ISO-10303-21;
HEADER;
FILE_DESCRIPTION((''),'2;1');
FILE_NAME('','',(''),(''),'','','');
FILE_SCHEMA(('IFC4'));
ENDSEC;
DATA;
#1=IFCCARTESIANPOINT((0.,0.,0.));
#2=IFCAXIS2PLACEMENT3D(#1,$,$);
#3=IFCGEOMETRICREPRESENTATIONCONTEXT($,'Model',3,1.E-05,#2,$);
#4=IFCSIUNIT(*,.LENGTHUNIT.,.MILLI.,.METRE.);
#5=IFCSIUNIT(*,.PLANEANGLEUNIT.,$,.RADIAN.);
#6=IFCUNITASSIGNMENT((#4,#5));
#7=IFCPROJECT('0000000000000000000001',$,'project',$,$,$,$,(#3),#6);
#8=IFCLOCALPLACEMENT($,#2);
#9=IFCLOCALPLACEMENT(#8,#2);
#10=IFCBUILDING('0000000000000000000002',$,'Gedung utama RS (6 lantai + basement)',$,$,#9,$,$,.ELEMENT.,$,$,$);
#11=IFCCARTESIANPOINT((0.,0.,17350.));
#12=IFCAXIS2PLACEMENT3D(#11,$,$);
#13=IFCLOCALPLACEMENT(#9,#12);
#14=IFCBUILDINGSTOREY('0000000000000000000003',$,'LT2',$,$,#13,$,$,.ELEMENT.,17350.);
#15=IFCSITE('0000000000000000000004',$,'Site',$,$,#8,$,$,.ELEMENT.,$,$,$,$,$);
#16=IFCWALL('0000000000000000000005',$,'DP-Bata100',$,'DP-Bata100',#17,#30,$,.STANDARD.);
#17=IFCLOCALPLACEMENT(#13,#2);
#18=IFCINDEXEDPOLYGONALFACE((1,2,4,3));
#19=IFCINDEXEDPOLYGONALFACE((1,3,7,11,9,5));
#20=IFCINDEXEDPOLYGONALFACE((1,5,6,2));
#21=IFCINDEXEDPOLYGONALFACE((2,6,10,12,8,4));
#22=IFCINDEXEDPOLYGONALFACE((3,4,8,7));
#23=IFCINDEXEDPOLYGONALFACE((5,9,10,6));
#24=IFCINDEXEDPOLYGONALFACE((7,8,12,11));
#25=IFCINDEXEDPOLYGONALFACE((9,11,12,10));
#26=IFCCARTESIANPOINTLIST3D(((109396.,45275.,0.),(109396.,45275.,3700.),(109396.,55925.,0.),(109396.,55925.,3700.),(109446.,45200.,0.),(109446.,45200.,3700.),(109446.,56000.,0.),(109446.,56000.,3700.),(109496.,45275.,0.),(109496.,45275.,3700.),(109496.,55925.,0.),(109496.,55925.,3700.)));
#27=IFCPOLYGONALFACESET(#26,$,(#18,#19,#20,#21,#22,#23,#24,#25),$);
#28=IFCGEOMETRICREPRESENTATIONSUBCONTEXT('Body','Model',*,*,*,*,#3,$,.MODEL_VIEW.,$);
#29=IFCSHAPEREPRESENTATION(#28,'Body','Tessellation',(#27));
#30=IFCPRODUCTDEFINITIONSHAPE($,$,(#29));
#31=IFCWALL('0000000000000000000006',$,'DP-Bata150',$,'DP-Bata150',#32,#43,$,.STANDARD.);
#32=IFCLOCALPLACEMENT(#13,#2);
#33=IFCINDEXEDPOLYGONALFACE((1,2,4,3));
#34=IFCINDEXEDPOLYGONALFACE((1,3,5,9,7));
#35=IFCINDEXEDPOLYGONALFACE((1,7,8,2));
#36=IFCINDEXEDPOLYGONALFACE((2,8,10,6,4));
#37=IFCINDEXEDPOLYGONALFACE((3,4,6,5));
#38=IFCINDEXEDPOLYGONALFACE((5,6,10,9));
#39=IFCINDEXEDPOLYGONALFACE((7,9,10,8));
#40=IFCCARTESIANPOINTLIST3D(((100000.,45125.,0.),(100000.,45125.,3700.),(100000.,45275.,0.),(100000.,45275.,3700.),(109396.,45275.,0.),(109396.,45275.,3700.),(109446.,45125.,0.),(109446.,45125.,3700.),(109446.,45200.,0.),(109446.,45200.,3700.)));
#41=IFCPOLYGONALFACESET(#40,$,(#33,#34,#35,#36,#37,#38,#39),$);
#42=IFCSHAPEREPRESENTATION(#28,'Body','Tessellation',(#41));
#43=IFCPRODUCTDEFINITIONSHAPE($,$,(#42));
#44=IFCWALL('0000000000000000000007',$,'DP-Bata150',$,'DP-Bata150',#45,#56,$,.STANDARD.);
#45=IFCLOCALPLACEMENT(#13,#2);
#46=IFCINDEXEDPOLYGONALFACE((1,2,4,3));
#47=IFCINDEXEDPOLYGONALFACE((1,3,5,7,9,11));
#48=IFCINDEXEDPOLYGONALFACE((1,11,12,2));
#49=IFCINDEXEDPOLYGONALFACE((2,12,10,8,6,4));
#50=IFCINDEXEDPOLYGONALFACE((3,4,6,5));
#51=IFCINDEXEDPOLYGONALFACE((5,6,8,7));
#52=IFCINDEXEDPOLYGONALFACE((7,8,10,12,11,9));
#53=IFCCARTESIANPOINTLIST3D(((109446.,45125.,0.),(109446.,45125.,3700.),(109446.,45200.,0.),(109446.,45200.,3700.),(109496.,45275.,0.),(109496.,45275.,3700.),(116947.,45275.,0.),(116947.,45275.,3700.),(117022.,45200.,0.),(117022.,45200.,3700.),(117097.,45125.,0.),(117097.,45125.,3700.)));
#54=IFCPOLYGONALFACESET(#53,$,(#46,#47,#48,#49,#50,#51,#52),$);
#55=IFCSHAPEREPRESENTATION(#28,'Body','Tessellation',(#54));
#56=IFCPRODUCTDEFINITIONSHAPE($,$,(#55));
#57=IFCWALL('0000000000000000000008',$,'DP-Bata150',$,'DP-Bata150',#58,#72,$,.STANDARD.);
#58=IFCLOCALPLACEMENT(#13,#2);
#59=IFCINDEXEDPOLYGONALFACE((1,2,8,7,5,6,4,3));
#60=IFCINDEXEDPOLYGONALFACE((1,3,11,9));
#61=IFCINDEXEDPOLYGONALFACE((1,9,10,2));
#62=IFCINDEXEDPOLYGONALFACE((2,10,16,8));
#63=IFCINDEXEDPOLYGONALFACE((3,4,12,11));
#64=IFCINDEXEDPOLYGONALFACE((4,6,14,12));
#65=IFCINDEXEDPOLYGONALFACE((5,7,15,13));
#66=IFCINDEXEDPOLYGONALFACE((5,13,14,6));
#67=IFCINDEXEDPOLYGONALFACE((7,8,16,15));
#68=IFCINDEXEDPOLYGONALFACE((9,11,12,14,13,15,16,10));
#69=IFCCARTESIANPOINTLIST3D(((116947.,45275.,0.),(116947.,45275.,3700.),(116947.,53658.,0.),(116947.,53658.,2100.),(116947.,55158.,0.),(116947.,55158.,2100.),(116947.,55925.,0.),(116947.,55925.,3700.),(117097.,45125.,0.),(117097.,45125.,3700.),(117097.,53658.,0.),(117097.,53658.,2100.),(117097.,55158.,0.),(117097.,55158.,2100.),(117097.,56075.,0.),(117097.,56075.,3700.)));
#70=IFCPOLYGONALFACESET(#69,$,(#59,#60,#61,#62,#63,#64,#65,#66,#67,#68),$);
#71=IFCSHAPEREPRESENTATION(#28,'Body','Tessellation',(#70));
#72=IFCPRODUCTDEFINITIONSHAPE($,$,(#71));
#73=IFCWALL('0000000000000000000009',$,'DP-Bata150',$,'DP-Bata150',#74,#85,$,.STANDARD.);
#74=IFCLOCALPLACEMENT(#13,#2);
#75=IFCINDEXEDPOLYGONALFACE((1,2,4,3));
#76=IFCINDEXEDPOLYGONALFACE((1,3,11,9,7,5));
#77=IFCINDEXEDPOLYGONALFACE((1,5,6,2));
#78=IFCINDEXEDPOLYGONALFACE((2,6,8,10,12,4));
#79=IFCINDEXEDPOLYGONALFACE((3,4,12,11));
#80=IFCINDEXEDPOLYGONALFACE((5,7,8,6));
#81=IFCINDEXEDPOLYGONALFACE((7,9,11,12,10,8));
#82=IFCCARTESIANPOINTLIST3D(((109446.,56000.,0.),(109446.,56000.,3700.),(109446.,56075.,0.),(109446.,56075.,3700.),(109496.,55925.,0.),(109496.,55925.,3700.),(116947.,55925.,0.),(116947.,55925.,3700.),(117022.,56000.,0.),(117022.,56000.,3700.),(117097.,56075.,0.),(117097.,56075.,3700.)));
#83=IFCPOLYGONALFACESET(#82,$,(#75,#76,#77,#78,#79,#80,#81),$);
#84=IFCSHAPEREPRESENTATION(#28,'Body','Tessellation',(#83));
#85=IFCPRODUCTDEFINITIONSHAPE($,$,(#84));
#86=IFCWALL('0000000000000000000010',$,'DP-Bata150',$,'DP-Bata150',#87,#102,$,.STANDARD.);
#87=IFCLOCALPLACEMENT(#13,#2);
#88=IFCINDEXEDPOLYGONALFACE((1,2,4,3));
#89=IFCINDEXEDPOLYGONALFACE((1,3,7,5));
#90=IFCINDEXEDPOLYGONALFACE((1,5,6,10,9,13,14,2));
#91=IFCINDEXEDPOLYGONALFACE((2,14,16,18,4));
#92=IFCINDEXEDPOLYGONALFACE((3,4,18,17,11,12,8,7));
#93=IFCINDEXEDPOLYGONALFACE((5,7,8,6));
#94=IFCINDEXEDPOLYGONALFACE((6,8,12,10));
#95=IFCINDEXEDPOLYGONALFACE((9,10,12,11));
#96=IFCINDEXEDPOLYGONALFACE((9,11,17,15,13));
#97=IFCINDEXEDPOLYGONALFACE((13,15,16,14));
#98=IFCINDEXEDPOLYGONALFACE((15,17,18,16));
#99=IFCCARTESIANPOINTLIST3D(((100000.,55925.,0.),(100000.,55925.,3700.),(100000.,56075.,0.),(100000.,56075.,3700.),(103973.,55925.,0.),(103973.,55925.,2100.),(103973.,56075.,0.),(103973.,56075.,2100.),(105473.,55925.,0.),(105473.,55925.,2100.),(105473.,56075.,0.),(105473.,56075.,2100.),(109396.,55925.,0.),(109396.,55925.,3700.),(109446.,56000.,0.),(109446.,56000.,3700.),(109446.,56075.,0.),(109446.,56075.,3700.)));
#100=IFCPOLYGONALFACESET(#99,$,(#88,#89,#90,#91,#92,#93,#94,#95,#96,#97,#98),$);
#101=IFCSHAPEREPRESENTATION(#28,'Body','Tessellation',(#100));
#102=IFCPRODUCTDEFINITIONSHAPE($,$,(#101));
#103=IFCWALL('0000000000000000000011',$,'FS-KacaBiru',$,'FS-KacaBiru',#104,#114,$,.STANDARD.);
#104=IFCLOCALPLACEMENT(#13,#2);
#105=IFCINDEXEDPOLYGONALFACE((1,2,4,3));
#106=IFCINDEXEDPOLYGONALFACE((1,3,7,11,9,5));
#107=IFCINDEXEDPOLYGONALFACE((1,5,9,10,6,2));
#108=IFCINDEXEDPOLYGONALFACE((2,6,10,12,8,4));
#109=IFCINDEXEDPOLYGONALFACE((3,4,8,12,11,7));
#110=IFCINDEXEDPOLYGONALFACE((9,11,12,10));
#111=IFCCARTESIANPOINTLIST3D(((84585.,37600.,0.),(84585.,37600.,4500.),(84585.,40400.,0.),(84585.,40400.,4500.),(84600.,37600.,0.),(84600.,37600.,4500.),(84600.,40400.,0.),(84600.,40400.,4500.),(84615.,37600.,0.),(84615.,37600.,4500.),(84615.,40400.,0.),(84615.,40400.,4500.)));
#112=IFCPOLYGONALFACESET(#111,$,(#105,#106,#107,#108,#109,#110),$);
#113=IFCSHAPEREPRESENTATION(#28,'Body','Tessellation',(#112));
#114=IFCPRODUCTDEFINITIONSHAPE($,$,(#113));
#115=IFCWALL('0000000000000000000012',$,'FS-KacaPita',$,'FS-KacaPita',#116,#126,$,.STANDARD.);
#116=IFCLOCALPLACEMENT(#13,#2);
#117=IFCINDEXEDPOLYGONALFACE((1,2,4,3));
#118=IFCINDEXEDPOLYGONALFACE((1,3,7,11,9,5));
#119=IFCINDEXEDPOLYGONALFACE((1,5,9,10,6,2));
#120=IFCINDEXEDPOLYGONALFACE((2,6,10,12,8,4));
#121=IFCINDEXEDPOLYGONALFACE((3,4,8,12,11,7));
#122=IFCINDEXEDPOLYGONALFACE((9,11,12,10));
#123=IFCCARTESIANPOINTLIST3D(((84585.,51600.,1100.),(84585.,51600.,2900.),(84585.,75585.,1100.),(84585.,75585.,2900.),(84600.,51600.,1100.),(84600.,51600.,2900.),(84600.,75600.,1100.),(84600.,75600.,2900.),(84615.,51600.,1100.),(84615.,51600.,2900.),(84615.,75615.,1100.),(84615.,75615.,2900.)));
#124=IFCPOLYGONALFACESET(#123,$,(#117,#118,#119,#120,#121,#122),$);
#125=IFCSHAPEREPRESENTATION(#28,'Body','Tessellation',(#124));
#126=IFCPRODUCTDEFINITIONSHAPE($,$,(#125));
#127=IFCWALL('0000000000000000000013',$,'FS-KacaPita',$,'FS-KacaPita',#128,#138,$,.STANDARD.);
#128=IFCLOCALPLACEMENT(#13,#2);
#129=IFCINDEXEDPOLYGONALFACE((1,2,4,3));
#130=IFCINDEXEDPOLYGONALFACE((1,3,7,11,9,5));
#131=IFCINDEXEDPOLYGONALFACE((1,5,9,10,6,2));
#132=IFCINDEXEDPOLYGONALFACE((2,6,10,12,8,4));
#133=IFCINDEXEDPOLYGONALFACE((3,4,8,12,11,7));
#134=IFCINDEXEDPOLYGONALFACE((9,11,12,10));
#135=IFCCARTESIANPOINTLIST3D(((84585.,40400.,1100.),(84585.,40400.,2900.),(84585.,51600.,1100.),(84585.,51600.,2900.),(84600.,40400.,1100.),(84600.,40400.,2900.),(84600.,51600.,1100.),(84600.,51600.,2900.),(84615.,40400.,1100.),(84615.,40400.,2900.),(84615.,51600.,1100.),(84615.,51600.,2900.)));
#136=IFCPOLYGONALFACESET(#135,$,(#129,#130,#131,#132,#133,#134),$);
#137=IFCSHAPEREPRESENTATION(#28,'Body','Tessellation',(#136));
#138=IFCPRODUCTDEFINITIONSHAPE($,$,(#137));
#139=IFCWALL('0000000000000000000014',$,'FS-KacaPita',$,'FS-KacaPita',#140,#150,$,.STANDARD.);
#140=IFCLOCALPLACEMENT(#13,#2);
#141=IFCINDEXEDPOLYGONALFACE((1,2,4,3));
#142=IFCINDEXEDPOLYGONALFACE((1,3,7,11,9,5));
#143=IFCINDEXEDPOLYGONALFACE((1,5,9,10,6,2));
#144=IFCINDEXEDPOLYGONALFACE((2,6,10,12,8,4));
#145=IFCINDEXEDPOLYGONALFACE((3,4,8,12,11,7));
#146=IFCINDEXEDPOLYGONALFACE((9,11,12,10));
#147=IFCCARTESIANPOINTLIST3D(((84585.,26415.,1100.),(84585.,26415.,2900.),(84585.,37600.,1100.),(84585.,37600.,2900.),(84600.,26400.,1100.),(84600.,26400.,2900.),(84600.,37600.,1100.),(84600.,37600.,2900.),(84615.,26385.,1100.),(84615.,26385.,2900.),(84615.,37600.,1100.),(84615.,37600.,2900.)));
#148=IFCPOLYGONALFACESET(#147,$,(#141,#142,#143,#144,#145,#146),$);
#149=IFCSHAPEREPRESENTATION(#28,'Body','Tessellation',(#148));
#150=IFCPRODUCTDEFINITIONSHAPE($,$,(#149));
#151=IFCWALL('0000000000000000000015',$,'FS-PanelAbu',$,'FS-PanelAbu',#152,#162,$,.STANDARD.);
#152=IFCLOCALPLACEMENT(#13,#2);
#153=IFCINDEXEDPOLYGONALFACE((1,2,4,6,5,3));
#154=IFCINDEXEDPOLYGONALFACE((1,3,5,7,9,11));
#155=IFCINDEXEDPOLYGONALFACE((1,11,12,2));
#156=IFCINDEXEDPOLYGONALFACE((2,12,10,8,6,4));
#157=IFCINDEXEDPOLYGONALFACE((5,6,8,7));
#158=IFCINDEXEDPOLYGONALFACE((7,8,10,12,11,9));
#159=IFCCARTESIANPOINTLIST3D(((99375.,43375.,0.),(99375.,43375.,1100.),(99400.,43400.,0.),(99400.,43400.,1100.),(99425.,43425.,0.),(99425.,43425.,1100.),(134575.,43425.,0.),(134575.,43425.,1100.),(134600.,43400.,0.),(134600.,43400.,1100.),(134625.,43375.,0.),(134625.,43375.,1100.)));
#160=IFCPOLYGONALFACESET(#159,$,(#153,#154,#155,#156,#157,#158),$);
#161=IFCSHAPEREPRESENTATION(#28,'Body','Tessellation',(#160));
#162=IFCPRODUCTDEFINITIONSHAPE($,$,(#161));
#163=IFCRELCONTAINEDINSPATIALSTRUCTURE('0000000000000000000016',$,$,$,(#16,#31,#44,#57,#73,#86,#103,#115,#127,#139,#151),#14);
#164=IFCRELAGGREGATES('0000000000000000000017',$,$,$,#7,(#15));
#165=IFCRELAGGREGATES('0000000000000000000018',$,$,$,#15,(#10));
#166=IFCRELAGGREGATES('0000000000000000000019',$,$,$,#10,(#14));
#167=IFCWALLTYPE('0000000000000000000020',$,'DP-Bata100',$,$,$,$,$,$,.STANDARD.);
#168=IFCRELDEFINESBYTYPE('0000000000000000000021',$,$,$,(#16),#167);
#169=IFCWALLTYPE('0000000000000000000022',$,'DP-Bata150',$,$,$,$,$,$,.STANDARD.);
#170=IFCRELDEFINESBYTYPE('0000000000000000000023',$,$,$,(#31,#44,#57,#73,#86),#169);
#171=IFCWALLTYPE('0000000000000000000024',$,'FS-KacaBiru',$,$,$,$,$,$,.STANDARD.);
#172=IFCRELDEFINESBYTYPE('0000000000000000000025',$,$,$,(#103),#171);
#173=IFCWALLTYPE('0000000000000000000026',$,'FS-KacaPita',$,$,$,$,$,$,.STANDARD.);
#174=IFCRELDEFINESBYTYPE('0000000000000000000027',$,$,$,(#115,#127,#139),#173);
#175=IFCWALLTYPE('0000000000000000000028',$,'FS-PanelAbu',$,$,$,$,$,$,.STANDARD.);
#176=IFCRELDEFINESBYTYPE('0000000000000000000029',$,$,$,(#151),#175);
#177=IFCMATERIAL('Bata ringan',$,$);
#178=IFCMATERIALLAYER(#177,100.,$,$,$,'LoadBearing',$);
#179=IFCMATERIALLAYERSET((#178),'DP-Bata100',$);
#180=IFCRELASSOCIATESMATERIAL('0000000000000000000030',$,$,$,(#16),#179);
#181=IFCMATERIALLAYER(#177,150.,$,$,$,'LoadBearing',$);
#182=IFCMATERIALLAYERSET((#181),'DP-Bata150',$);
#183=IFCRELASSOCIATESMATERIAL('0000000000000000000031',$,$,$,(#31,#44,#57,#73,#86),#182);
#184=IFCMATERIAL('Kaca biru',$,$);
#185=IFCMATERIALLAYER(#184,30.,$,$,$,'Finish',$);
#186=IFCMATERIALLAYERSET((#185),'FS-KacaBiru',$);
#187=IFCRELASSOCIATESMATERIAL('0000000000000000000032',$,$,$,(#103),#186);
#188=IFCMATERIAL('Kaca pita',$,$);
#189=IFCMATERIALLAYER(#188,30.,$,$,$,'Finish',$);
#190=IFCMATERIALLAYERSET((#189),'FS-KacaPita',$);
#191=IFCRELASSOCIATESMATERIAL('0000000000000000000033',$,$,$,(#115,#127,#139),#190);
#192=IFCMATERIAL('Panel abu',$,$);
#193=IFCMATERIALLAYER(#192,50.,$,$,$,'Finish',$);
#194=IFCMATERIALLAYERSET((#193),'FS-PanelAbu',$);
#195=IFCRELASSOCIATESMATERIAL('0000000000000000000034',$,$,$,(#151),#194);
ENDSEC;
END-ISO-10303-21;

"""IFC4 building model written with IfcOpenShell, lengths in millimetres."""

from ifc_helpers import new_model, si_unit, frame, frame_2d, origin, place, context, subcontext, project, spatial, polyline, rectangle, outline, extrude, material, layer, layer_set, layer_usage, type_object, element, save


model = new_model("IFC4")

# Units and contexts
model_context = context("Model", 3, precision=1e-05, world=origin())
body_context = subcontext(model_context, "Body", "Model", "MODEL_VIEW")
ifc_project = project(units=[si_unit("LENGTHUNIT", "METRE", prefix="MILLI"), si_unit("PLANEANGLEUNIT", "RADIAN")], contexts=[model_context])

# Site, building, storey
site_placement = place(None, origin())
site = spatial("IfcSite", under=ifc_project, at=site_placement, Name="Site", CompositionType="ELEMENT")
building_placement = place(site_placement, origin())
building = spatial("IfcBuilding", under=site, at=building_placement, Name="Gedung utama RS (6 lantai + basement)", CompositionType="ELEMENT")
storey_placement = place(building_placement, frame((0.0, 0.0, 17350.0)))
storey = spatial("IfcBuildingStorey", under=building, at=storey_placement, Name="LT2", CompositionType="ELEMENT", Elevation=17350.0)

# Walls
ifc_material_1 = material(Name="Bata ringan")
ifc_layer_1 = layer(ifc_material_1, 100.0, Category="LoadBearing")
ifc_layer_set_1 = layer_set([ifc_layer_1], Name="DP-Bata100")
ifc_layer_usage_1 = layer_usage(ifc_layer_set_1, "AXIS2", "NEGATIVE", 50.0)
wall_type_1 = type_object("IfcWallType", Name="DP-Bata100", PredefinedType="STANDARD")
wall_1_placement = place(storey_placement, frame((109446.0, 45200.0, 0.0), z_axis=(0.0, 0.0, 1.0), x_axis=(0.0, 1.0, 0.0)))
element("IfcWall", 1, at=wall_1_placement, inside=storey, type_object=wall_type_1, material=ifc_layer_usage_1, Name="DP-Bata100", ObjectType="DP-Bata100", PredefinedType="STANDARD", context=body_context, shape_type="SweptSolid", body=[
    extrude(outline(polyline([(75.0, -50.0), (0.0, 0.0), (75.0, 50.0), (10725.0, 50.0), (10800.0, 0.0), (10725.0, -50.0), (75.0, -50.0)])), origin(), (0.0, 0.0, 1.0), 3700.0),
])
ifc_layer_2 = layer(ifc_material_1, 150.0, Category="LoadBearing")
ifc_layer_set_2 = layer_set([ifc_layer_2], Name="DP-Bata150")
ifc_layer_usage_2 = layer_usage(ifc_layer_set_2, "AXIS2", "NEGATIVE", 75.0)
wall_type_2 = type_object("IfcWallType", Name="DP-Bata150", PredefinedType="STANDARD")
wall_2_placement = place(storey_placement, frame((100000.0, 45200.0, 0.0), z_axis=(0.0, 0.0, 1.0), x_axis=(1.0, 0.0, 0.0)))
element("IfcWall", 2, at=wall_2_placement, inside=storey, type_object=wall_type_2, material=ifc_layer_usage_2, Name="DP-Bata150", ObjectType="DP-Bata150", PredefinedType="STANDARD", context=body_context, shape_type="SweptSolid", body=[
    extrude(outline(polyline([(0.0, -75.0), (0.0, 75.0), (9396.0, 75.0), (9446.0, 0.0), (9446.0, -75.0), (0.0, -75.0)])), origin(), (0.0, 0.0, 1.0), 3700.0),
])
wall_3_placement = place(storey_placement, frame((109446.0, 45200.0, 0.0), z_axis=(0.0, 0.0, 1.0), x_axis=(1.0, 0.0, 0.0)))
element("IfcWall", 3, at=wall_3_placement, inside=storey, type_object=wall_type_2, material=ifc_layer_usage_2, Name="DP-Bata150", ObjectType="DP-Bata150", PredefinedType="STANDARD", context=body_context, shape_type="SweptSolid", body=[
    extrude(outline(polyline([(0.0, -75.0), (0.0, 0.0), (50.0, 75.0), (7501.0, 75.0), (7576.0, 0.0), (7651.0, -75.0), (0.0, -75.0)])), origin(), (0.0, 0.0, 1.0), 3700.0),
])

# Wall, opening
wall_4_placement = place(storey_placement, frame((117022.0, 45200.0, 0.0), z_axis=(0.0, 0.0, 1.0), x_axis=(0.0, 1.0, 0.0)))
wall_4 = element("IfcWall", 4, at=wall_4_placement, inside=storey, type_object=wall_type_2, material=ifc_layer_usage_2, Name="DP-Bata150", ObjectType="DP-Bata150", PredefinedType="STANDARD", context=body_context, shape_type="SweptSolid", body=[
    extrude(outline(polyline([(-75.0, -75.0), (0.0, 0.0), (75.0, 75.0), (10725.0, 75.0), (10800.0, 0.0), (10875.0, -75.0), (-75.0, -75.0)])), origin(), (0.0, 0.0, 1.0), 3700.0),
])
opening_1_placement = place(wall_4_placement, frame((8458.0, 0.0, 0.0), z_axis=(0.0, 0.0, 1.0), x_axis=(1.0, 0.0, 0.0)))
element("IfcOpeningElement", 5, at=opening_1_placement, cuts=wall_4, PredefinedType="OPENING", context=body_context, shape_type="SweptSolid", body=[
    extrude(rectangle(XDim=1500.0, YDim=170.0, at=frame_2d((750.0, 0.0))), origin(), (0.0, 0.0, 1.0), 2100.0),
])

# Wall
wall_5_placement = place(storey_placement, frame((117022.0, 56000.0, 0.0), z_axis=(0.0, 0.0, 1.0), x_axis=(-1.0, 0.0, 0.0)))
element("IfcWall", 6, at=wall_5_placement, inside=storey, type_object=wall_type_2, material=ifc_layer_usage_2, Name="DP-Bata150", ObjectType="DP-Bata150", PredefinedType="STANDARD", context=body_context, shape_type="SweptSolid", body=[
    extrude(outline(polyline([(-75.0, -75.0), (0.0, 0.0), (75.0, 75.0), (7526.0, 75.0), (7576.0, 0.0), (7576.0, -75.0), (-75.0, -75.0)])), origin(), (0.0, 0.0, 1.0), 3700.0),
])

# Wall, opening
wall_6_placement = place(storey_placement, frame((109446.0, 56000.0, 0.0), z_axis=(0.0, 0.0, 1.0), x_axis=(-1.0, 0.0, 0.0)))
wall_6 = element("IfcWall", 7, at=wall_6_placement, inside=storey, type_object=wall_type_2, material=ifc_layer_usage_2, Name="DP-Bata150", ObjectType="DP-Bata150", PredefinedType="STANDARD", context=body_context, shape_type="SweptSolid", body=[
    extrude(outline(polyline([(0.0, -75.0), (0.0, 0.0), (50.0, 75.0), (9446.0, 75.0), (9446.0, -75.0), (0.0, -75.0)])), origin(), (0.0, 0.0, 1.0), 3700.0),
])
opening_2_placement = place(wall_6_placement, frame((3973.0, 0.0, 0.0), z_axis=(0.0, 0.0, 1.0), x_axis=(1.0, 0.0, 0.0)))
element("IfcOpeningElement", 8, at=opening_2_placement, cuts=wall_6, PredefinedType="OPENING", context=body_context, shape_type="SweptSolid", body=[
    extrude(rectangle(XDim=1500.0, YDim=170.0, at=frame_2d((750.0, 0.0))), origin(), (0.0, 0.0, 1.0), 2100.0),
])

# Walls
ifc_material_2 = material(Name="Kaca biru")
ifc_layer_3 = layer(ifc_material_2, 30.0, Category="Finish")
ifc_layer_set_3 = layer_set([ifc_layer_3], Name="FS-KacaBiru")
ifc_layer_usage_3 = layer_usage(ifc_layer_set_3, "AXIS2", "NEGATIVE", 15.0)
wall_type_3 = type_object("IfcWallType", Name="FS-KacaBiru", PredefinedType="STANDARD")
wall_7_placement = place(storey_placement, frame((84600.0, 40400.0, 0.0), z_axis=(0.0, 0.0, 1.0), x_axis=(0.0, -1.0, 0.0)))
element("IfcWall", 9, at=wall_7_placement, inside=storey, type_object=wall_type_3, material=ifc_layer_usage_3, Name="FS-KacaBiru", ObjectType="FS-KacaBiru", PredefinedType="STANDARD", context=body_context, shape_type="SweptSolid", body=[
    extrude(outline(polyline([(0.0, -15.0), (0.0, 0.0), (0.0, 15.0), (2800.0, 15.0), (2800.0, 0.0), (2800.0, -15.0), (0.0, -15.0)])), origin(), (0.0, 0.0, 1.0), 4500.0),
])
ifc_material_3 = material(Name="Kaca pita")
ifc_layer_4 = layer(ifc_material_3, 30.0, Category="Finish")
ifc_layer_set_4 = layer_set([ifc_layer_4], Name="FS-KacaPita")
ifc_layer_usage_4 = layer_usage(ifc_layer_set_4, "AXIS2", "NEGATIVE", 15.0)
wall_type_4 = type_object("IfcWallType", Name="FS-KacaPita", PredefinedType="STANDARD")
wall_8_placement = place(storey_placement, frame((84600.0, 75600.0, 1100.0), z_axis=(0.0, 0.0, 1.0), x_axis=(0.0, -1.0, 0.0)))
element("IfcWall", 10, at=wall_8_placement, inside=storey, type_object=wall_type_4, material=ifc_layer_usage_4, Name="FS-KacaPita", ObjectType="FS-KacaPita", PredefinedType="STANDARD", context=body_context, shape_type="SweptSolid", body=[
    extrude(outline(polyline([(15.0, -15.0), (0.0, 0.0), (-15.0, 15.0), (24000.0, 15.0), (24000.0, 0.0), (24000.0, -15.0), (15.0, -15.0)])), origin(), (0.0, 0.0, 1.0), 1800.0),
])
wall_9_placement = place(storey_placement, frame((84600.0, 51600.0, 1100.0), z_axis=(0.0, 0.0, 1.0), x_axis=(0.0, -1.0, 0.0)))
element("IfcWall", 11, at=wall_9_placement, inside=storey, type_object=wall_type_4, material=ifc_layer_usage_4, Name="FS-KacaPita", ObjectType="FS-KacaPita", PredefinedType="STANDARD", context=body_context, shape_type="SweptSolid", body=[
    extrude(outline(polyline([(0.0, -15.0), (0.0, 0.0), (0.0, 15.0), (11200.0, 15.0), (11200.0, 0.0), (11200.0, -15.0), (0.0, -15.0)])), origin(), (0.0, 0.0, 1.0), 1800.0),
])
wall_10_placement = place(storey_placement, frame((84600.0, 37600.0, 1100.0), z_axis=(0.0, 0.0, 1.0), x_axis=(0.0, -1.0, 0.0)))
element("IfcWall", 12, at=wall_10_placement, inside=storey, type_object=wall_type_4, material=ifc_layer_usage_4, Name="FS-KacaPita", ObjectType="FS-KacaPita", PredefinedType="STANDARD", context=body_context, shape_type="SweptSolid", body=[
    extrude(outline(polyline([(0.0, -15.0), (0.0, 0.0), (0.0, 15.0), (11215.0, 15.0), (11200.0, 0.0), (11185.0, -15.0), (0.0, -15.0)])), origin(), (0.0, 0.0, 1.0), 1800.0),
])
ifc_material_4 = material(Name="Panel abu")
ifc_layer_5 = layer(ifc_material_4, 50.0, Category="Finish")
ifc_layer_set_5 = layer_set([ifc_layer_5], Name="FS-PanelAbu")
ifc_layer_usage_5 = layer_usage(ifc_layer_set_5, "AXIS2", "NEGATIVE", 25.0)
wall_type_5 = type_object("IfcWallType", Name="FS-PanelAbu", PredefinedType="STANDARD")
wall_11_placement = place(storey_placement, frame((134600.0, 43400.0, 0.0), z_axis=(0.0, 0.0, 1.0), x_axis=(-1.0, 0.0, 0.0)))
element("IfcWall", 13, at=wall_11_placement, inside=storey, type_object=wall_type_5, material=ifc_layer_usage_5, Name="FS-PanelAbu", ObjectType="FS-PanelAbu", PredefinedType="STANDARD", context=body_context, shape_type="SweptSolid", body=[
    extrude(outline(polyline([(25.0, -25.0), (0.0, 0.0), (-25.0, 25.0), (35225.0, 25.0), (35200.0, 0.0), (35175.0, -25.0), (25.0, -25.0)])), origin(), (0.0, 0.0, 1.0), 1100.0),
])

save(model, "model.ifc")
